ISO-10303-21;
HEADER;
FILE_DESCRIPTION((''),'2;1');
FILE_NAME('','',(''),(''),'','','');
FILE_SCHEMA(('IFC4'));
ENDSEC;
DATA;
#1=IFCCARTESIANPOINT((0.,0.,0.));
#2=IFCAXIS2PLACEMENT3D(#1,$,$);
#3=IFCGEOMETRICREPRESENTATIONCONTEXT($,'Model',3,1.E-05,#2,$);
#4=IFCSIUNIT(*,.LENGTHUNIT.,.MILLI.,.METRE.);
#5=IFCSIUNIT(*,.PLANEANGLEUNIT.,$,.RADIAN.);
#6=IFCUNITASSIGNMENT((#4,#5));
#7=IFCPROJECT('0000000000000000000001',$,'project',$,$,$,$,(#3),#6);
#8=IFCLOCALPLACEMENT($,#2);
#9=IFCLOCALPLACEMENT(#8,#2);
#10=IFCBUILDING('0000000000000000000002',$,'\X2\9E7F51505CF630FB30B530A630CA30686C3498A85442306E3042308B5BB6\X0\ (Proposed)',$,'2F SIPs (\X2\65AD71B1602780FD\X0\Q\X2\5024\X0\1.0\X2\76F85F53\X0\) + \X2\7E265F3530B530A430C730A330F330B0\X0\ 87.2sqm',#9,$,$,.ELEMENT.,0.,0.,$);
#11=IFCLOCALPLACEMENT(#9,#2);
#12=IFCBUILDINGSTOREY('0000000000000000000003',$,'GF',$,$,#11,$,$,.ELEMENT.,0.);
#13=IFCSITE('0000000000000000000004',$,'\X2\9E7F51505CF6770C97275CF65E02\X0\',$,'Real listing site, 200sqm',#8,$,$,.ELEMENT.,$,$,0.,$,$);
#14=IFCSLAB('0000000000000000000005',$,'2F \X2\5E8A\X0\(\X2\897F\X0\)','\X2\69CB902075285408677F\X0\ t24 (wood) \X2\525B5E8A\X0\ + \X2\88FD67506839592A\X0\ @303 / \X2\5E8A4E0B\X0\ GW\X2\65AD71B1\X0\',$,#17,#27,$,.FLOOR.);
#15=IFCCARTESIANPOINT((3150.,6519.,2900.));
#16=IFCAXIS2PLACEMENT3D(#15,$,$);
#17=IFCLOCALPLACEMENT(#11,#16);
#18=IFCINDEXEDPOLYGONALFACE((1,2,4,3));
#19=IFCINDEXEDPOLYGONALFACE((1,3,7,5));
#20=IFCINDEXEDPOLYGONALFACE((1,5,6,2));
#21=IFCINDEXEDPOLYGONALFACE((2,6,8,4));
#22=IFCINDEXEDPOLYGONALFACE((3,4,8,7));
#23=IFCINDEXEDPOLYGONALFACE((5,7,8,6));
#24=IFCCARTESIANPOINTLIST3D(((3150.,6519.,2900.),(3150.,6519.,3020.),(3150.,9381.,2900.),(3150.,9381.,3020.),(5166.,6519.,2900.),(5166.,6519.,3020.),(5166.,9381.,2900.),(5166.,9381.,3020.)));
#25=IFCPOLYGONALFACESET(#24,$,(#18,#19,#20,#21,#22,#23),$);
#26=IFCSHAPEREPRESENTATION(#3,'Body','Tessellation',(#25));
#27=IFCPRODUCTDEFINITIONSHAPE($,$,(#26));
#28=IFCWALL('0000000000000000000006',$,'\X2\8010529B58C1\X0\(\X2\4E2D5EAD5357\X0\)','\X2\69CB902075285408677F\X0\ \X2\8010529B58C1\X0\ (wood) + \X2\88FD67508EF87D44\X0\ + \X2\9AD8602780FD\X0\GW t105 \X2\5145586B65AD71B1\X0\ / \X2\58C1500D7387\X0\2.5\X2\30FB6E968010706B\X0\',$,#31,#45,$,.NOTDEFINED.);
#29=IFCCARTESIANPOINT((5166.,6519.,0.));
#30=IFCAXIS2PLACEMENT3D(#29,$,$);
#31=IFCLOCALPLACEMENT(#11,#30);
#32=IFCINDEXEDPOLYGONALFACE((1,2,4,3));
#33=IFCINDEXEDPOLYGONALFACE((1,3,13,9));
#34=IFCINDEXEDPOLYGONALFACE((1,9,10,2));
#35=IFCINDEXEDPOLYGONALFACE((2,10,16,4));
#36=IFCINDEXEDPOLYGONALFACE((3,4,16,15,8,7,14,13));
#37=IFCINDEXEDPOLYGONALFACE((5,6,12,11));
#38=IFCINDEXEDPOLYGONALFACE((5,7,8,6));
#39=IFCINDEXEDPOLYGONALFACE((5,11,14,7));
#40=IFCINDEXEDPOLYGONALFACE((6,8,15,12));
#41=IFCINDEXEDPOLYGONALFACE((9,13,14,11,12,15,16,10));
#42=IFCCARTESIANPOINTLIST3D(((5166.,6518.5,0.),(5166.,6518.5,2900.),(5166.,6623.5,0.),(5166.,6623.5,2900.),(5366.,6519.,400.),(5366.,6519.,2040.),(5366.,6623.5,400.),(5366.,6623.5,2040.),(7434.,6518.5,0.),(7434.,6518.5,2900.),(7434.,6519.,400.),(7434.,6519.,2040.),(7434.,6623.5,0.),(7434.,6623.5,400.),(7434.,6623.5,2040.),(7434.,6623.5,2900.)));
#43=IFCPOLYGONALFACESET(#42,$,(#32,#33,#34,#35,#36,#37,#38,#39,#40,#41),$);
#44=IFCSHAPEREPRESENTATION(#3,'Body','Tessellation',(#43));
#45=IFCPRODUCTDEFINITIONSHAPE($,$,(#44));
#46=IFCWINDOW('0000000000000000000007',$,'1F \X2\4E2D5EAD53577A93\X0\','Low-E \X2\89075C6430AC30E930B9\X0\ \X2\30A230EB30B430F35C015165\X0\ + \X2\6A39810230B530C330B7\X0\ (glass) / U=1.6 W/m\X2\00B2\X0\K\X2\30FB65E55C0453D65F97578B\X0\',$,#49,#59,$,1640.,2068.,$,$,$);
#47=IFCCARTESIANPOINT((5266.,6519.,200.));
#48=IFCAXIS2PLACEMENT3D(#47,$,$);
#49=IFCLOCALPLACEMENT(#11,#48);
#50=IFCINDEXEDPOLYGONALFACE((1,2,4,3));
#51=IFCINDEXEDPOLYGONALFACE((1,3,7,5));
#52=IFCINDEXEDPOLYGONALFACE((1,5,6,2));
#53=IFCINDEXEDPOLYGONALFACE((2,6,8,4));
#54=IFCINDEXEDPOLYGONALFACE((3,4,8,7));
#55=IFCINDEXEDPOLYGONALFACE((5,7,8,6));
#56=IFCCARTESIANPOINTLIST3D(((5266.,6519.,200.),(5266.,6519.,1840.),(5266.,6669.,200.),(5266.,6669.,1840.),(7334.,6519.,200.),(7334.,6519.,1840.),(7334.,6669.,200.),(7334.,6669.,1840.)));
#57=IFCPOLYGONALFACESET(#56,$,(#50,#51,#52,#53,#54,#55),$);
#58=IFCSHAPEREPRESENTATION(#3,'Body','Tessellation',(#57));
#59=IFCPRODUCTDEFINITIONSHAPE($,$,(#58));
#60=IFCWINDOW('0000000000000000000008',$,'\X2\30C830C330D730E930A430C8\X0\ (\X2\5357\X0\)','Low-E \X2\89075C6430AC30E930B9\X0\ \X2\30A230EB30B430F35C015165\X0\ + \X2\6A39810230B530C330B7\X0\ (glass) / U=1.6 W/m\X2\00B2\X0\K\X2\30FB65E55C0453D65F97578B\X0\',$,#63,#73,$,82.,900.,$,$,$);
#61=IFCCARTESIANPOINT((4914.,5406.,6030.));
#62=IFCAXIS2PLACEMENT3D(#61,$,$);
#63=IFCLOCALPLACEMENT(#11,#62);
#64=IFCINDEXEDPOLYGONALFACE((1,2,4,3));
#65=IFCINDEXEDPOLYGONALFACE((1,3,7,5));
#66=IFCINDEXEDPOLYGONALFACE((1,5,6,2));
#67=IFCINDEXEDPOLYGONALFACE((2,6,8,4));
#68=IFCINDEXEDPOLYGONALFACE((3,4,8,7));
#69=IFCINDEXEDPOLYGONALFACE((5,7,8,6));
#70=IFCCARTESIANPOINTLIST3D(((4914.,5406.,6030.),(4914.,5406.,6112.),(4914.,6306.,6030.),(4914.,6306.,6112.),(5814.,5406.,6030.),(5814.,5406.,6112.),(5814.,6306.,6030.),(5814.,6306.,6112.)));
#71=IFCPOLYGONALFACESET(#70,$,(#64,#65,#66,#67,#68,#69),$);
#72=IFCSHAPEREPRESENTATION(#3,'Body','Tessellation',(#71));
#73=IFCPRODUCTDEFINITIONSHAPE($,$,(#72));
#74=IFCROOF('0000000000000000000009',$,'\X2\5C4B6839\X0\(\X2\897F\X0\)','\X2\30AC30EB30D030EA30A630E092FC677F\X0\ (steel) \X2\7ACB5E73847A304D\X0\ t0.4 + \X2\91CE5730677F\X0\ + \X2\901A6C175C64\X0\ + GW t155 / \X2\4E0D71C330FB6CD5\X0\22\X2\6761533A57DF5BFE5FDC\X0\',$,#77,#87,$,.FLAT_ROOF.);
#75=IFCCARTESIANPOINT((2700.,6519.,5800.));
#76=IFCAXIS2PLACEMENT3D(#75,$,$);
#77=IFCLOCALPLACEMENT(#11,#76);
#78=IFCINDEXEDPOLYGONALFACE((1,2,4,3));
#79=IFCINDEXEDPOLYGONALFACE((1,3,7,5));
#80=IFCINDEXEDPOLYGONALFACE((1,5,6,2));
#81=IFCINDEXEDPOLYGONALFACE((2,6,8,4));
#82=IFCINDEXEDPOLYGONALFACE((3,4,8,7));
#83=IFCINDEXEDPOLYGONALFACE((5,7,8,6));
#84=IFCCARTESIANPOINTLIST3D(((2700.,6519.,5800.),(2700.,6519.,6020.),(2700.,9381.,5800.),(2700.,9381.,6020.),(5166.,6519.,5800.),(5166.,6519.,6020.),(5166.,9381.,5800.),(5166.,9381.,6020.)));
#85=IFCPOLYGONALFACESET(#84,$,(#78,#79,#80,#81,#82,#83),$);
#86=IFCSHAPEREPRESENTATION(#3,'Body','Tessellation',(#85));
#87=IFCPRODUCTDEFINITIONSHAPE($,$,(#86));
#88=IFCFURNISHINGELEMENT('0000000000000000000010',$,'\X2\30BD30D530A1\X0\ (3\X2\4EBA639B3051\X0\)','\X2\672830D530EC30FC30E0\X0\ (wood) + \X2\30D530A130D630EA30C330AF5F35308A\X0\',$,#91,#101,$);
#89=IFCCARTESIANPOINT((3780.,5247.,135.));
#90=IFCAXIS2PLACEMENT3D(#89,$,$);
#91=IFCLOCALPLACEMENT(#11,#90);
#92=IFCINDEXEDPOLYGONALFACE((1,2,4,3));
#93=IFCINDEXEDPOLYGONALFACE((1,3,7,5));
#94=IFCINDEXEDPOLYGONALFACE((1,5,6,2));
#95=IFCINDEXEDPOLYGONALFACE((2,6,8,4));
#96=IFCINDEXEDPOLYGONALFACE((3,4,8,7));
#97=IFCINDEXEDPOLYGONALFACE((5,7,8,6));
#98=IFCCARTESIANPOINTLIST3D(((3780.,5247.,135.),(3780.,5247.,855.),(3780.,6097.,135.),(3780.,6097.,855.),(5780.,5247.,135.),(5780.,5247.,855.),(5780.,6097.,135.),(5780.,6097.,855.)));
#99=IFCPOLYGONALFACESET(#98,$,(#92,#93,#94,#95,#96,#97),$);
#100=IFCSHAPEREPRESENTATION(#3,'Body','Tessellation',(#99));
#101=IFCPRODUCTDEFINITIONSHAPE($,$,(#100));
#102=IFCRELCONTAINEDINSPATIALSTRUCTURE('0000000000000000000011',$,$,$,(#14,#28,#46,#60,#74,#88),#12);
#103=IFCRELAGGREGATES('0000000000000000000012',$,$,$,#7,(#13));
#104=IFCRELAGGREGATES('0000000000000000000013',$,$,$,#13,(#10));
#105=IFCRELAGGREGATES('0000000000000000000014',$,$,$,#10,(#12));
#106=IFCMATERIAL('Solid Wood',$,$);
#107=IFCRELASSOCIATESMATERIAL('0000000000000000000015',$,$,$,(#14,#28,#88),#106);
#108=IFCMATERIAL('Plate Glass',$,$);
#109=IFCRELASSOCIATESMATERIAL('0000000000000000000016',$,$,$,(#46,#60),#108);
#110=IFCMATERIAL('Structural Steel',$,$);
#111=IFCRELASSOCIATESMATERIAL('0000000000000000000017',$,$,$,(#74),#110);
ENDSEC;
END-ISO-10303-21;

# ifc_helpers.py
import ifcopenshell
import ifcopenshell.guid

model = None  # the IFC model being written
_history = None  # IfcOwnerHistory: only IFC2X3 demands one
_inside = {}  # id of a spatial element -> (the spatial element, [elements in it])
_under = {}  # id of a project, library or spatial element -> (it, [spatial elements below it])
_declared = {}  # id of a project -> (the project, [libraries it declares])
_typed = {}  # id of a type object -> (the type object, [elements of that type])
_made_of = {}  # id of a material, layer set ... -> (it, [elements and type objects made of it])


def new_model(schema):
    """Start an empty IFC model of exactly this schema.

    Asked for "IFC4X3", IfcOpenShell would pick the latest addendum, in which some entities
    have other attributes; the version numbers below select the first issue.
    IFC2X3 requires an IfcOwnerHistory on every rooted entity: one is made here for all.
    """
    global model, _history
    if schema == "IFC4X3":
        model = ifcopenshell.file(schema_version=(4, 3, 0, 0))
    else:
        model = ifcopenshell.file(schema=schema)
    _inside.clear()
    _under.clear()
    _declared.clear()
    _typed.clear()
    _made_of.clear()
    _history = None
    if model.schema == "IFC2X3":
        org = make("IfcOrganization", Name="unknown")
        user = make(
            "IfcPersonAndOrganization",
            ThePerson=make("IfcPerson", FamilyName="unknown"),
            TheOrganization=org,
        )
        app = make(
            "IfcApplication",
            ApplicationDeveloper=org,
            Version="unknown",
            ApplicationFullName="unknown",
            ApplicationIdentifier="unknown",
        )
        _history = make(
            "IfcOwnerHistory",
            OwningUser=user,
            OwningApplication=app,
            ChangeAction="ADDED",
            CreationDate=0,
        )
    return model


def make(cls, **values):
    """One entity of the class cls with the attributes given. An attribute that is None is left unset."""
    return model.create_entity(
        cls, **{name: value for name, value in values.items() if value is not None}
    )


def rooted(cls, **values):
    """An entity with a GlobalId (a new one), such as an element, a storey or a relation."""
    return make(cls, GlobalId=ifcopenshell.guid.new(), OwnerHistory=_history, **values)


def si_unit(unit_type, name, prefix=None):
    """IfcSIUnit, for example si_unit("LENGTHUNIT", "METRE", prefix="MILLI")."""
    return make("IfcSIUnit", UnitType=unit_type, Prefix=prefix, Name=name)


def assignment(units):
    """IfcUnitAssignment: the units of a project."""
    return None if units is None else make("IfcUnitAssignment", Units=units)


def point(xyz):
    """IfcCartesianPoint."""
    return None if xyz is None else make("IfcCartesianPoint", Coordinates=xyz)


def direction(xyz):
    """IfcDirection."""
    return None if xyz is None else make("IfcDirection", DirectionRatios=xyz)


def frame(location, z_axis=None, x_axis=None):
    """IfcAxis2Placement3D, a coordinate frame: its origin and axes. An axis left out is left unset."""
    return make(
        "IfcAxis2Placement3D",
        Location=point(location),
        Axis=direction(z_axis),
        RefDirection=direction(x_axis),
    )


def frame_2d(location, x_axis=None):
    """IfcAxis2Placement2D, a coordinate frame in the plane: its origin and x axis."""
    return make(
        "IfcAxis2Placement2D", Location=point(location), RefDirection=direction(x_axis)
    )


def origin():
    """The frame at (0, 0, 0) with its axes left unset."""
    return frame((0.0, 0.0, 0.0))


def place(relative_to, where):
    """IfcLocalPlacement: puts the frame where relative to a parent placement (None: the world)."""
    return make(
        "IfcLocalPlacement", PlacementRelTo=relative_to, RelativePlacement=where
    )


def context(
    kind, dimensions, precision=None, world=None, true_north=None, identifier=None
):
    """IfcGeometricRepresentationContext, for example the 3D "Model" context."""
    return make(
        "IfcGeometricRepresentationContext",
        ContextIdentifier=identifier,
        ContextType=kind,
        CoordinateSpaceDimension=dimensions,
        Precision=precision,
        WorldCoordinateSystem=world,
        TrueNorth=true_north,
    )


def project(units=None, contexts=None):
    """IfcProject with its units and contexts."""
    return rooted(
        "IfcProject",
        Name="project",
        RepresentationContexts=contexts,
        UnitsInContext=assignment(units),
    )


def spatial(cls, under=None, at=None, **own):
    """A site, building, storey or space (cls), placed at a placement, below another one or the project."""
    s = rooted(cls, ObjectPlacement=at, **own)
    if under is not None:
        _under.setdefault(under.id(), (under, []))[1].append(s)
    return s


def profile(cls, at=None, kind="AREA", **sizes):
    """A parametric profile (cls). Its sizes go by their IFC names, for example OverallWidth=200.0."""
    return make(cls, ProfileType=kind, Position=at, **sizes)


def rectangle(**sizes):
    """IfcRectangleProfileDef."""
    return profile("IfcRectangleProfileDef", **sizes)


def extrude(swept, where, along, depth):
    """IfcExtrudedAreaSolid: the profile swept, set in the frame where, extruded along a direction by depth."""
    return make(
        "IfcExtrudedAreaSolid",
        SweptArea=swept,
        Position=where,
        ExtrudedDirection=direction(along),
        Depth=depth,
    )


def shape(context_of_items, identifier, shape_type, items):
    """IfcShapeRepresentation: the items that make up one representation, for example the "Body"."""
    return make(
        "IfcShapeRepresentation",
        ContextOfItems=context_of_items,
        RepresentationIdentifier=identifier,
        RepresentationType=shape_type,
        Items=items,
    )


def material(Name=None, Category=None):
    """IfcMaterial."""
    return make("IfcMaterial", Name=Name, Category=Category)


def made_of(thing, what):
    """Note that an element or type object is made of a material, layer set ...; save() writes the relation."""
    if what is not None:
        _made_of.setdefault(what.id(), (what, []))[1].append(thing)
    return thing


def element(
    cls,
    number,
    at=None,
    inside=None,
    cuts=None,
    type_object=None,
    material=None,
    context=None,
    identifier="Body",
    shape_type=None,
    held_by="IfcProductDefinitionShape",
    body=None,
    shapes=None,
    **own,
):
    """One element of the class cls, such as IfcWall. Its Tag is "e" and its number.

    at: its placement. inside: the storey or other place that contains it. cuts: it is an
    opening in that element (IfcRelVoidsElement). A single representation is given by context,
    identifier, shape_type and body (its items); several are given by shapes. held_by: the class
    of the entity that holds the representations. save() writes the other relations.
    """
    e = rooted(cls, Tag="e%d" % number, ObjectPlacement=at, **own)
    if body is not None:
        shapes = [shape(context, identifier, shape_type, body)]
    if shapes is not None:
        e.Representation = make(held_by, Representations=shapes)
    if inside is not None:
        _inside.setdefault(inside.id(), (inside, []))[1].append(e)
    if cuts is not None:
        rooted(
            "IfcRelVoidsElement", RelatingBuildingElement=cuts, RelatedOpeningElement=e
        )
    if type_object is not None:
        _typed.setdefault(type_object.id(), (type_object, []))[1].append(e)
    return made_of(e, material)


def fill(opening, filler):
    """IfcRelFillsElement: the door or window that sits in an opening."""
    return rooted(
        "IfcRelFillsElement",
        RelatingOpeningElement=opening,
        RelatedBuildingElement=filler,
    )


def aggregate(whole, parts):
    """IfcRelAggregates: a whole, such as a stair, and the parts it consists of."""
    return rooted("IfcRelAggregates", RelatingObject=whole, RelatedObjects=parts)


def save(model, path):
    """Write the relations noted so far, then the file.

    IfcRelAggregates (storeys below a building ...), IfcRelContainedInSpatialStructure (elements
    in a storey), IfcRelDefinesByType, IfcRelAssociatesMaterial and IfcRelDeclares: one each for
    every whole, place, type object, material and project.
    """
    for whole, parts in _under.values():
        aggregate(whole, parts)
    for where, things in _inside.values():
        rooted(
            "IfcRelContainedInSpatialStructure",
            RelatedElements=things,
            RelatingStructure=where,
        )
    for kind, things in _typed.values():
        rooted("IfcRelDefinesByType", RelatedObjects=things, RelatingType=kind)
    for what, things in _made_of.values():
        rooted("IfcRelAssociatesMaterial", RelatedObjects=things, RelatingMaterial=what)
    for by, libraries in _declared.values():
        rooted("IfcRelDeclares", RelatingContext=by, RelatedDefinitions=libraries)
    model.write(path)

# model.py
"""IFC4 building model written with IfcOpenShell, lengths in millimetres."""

from ifc_helpers import new_model, si_unit, frame, frame_2d, origin, place, context, project, spatial, rectangle, extrude, material, element, fill, save


model = new_model("IFC4")

# Units and contexts
model_context = context("Model", 3, precision=1e-05, world=origin())
ifc_project = project(units=[si_unit("LENGTHUNIT", "METRE", prefix="MILLI"), si_unit("PLANEANGLEUNIT", "RADIAN")], contexts=[model_context])

# Site, building, storey
site_placement = place(None, origin())
site = spatial("IfcSite", under=ifc_project, at=site_placement, Name="鹿児島県霧島市", ObjectType="Real listing site, 200sqm", CompositionType="ELEMENT", RefElevation=0.0)
building_placement = place(site_placement, origin())
building = spatial("IfcBuilding", under=site, at=building_placement, Name="鹿児島・サウナと水風呂のある家 (Proposed)", ObjectType="2F SIPs (断熱性能Q値1.0相当) + 縦張サイディング 87.2sqm", CompositionType="ELEMENT", ElevationOfRefHeight=0.0, ElevationOfTerrain=0.0)
storey_placement = place(building_placement, origin())
storey = spatial("IfcBuildingStorey", under=building, at=storey_placement, Name="GF", CompositionType="ELEMENT", Elevation=0.0)

# Shared definitions
ifc_material_1 = material(Name="Solid Wood")

# Slab
slab_1_placement = place(storey_placement, frame((3150.0, 6519.0, 2900.0)))
element("IfcSlab", 1, at=slab_1_placement, inside=storey, material=ifc_material_1, Name="2F 床(西)", Description="構造用合板 t24 (wood) 剛床 + 製材根太 @303 / 床下 GW断熱", PredefinedType="FLOOR", context=model_context, shape_type="SweptSolid", body=[
    extrude(rectangle(XDim=2016.0, YDim=2862.0, at=frame_2d((1008.0, 1431.0))), frame((3150.0, 6519.0, 2900.0)), (0.0, 0.0, 1.0), 120.0),
])

# Wall, opening, window
wall_1_placement = place(storey_placement, frame((5166.0, 6519.0, 0.0)))
wall_1 = element("IfcWall", 2, at=wall_1_placement, inside=storey, material=ifc_material_1, Name="耐力壁(中庭南)", Description="構造用合板 耐力壁 (wood) + 製材軸組 + 高性能GW t105 充填断熱 / 壁倍率2.5・準耐火", PredefinedType="NOTDEFINED", context=model_context, shape_type="SweptSolid", body=[
    extrude(rectangle(XDim=2268.0, YDim=105.0, at=frame_2d((1134.0, 52.0))), frame((5166.0, 6519.0, 0.0)), (0.0, 0.0, 1.0), 2900.0),
])
opening_placement = place(storey_placement, frame((5266.0, 6519.0, 200.0)))
opening = element("IfcOpeningElement", 3, at=opening_placement, cuts=wall_1, PredefinedType="NOTDEFINED", context=model_context, shape_type="SweptSolid", body=[
    extrude(rectangle(XDim=2068.0, YDim=150.0, at=frame_2d((1034.0, 75.0))), frame((5266.0, 6519.0, 200.0)), (0.0, 0.0, 1.0), 1640.0),
])
ifc_material_2 = material(Name="Plate Glass")
window_1_placement = place(storey_placement, frame((5266.0, 6519.0, 200.0)))
window_1 = element("IfcWindow", 4, at=window_1_placement, inside=storey, material=ifc_material_2, Name="1F 中庭南窓", Description="Low-E 複層ガラス アルゴン封入 + 樹脂サッシ (glass) / U=1.6 W/m²K・日射取得型", OverallHeight=1640.0, OverallWidth=2068.0, context=model_context, shape_type="SweptSolid", body=[
    extrude(rectangle(XDim=2068.0, YDim=150.0, at=frame_2d((1034.0, 75.0))), frame((5266.0, 6519.0, 200.0)), (0.0, 0.0, 1.0), 1640.0),
])
fill(opening, window_1)

# Window
window_2_placement = place(storey_placement, frame((4914.0, 5406.0, 6030.0)))
element("IfcWindow", 5, at=window_2_placement, inside=storey, material=ifc_material_2, Name="トップライト (南)", Description="Low-E 複層ガラス アルゴン封入 + 樹脂サッシ (glass) / U=1.6 W/m²K・日射取得型", OverallHeight=82.0, OverallWidth=900.0, context=model_context, shape_type="SweptSolid", body=[
    extrude(rectangle(XDim=900.0, YDim=900.0, at=frame_2d((450.0, 450.0))), frame((4914.0, 5406.0, 6030.0)), (0.0, 0.0, 1.0), 82.0),
])

# Roof
ifc_material_3 = material(Name="Structural Steel")
for number, where, name in (
    (6, (2700.0, 6519.0, 5800.0), "屋根(西)"),
):
    element("IfcRoof", number, at=place(storey_placement, frame(where)), inside=storey, material=ifc_material_3, Name=name, Description="ガルバリウム鋼板 (steel) 立平葺き t0.4 + 野地板 + 通気層 + GW t155 / 不燃・法22条区域対応", PredefinedType="FLAT_ROOF", context=model_context, shape_type="SweptSolid", body=[
        extrude(rectangle(XDim=2466.0, YDim=2862.0, at=frame_2d((1233.0, 1431.0))), frame((2700.0, 6519.0, 5800.0)), (0.0, 0.0, 1.0), 220.0),
    ])

# Furnishing element
furnishing_placement = place(storey_placement, frame((3780.0, 5247.0, 135.0)))
element("IfcFurnishingElement", 7, at=furnishing_placement, inside=storey, material=ifc_material_1, Name="ソファ (3人掛け)", Description="木フレーム (wood) + ファブリック張り", context=model_context, shape_type="SweptSolid", body=[
    extrude(rectangle(XDim=2000.0, YDim=850.0, at=frame_2d((1000.0, 425.0))), frame((3780.0, 5247.0, 135.0)), (0.0, 0.0, 1.0), 720.0),
])

save(model, "model.ifc")
